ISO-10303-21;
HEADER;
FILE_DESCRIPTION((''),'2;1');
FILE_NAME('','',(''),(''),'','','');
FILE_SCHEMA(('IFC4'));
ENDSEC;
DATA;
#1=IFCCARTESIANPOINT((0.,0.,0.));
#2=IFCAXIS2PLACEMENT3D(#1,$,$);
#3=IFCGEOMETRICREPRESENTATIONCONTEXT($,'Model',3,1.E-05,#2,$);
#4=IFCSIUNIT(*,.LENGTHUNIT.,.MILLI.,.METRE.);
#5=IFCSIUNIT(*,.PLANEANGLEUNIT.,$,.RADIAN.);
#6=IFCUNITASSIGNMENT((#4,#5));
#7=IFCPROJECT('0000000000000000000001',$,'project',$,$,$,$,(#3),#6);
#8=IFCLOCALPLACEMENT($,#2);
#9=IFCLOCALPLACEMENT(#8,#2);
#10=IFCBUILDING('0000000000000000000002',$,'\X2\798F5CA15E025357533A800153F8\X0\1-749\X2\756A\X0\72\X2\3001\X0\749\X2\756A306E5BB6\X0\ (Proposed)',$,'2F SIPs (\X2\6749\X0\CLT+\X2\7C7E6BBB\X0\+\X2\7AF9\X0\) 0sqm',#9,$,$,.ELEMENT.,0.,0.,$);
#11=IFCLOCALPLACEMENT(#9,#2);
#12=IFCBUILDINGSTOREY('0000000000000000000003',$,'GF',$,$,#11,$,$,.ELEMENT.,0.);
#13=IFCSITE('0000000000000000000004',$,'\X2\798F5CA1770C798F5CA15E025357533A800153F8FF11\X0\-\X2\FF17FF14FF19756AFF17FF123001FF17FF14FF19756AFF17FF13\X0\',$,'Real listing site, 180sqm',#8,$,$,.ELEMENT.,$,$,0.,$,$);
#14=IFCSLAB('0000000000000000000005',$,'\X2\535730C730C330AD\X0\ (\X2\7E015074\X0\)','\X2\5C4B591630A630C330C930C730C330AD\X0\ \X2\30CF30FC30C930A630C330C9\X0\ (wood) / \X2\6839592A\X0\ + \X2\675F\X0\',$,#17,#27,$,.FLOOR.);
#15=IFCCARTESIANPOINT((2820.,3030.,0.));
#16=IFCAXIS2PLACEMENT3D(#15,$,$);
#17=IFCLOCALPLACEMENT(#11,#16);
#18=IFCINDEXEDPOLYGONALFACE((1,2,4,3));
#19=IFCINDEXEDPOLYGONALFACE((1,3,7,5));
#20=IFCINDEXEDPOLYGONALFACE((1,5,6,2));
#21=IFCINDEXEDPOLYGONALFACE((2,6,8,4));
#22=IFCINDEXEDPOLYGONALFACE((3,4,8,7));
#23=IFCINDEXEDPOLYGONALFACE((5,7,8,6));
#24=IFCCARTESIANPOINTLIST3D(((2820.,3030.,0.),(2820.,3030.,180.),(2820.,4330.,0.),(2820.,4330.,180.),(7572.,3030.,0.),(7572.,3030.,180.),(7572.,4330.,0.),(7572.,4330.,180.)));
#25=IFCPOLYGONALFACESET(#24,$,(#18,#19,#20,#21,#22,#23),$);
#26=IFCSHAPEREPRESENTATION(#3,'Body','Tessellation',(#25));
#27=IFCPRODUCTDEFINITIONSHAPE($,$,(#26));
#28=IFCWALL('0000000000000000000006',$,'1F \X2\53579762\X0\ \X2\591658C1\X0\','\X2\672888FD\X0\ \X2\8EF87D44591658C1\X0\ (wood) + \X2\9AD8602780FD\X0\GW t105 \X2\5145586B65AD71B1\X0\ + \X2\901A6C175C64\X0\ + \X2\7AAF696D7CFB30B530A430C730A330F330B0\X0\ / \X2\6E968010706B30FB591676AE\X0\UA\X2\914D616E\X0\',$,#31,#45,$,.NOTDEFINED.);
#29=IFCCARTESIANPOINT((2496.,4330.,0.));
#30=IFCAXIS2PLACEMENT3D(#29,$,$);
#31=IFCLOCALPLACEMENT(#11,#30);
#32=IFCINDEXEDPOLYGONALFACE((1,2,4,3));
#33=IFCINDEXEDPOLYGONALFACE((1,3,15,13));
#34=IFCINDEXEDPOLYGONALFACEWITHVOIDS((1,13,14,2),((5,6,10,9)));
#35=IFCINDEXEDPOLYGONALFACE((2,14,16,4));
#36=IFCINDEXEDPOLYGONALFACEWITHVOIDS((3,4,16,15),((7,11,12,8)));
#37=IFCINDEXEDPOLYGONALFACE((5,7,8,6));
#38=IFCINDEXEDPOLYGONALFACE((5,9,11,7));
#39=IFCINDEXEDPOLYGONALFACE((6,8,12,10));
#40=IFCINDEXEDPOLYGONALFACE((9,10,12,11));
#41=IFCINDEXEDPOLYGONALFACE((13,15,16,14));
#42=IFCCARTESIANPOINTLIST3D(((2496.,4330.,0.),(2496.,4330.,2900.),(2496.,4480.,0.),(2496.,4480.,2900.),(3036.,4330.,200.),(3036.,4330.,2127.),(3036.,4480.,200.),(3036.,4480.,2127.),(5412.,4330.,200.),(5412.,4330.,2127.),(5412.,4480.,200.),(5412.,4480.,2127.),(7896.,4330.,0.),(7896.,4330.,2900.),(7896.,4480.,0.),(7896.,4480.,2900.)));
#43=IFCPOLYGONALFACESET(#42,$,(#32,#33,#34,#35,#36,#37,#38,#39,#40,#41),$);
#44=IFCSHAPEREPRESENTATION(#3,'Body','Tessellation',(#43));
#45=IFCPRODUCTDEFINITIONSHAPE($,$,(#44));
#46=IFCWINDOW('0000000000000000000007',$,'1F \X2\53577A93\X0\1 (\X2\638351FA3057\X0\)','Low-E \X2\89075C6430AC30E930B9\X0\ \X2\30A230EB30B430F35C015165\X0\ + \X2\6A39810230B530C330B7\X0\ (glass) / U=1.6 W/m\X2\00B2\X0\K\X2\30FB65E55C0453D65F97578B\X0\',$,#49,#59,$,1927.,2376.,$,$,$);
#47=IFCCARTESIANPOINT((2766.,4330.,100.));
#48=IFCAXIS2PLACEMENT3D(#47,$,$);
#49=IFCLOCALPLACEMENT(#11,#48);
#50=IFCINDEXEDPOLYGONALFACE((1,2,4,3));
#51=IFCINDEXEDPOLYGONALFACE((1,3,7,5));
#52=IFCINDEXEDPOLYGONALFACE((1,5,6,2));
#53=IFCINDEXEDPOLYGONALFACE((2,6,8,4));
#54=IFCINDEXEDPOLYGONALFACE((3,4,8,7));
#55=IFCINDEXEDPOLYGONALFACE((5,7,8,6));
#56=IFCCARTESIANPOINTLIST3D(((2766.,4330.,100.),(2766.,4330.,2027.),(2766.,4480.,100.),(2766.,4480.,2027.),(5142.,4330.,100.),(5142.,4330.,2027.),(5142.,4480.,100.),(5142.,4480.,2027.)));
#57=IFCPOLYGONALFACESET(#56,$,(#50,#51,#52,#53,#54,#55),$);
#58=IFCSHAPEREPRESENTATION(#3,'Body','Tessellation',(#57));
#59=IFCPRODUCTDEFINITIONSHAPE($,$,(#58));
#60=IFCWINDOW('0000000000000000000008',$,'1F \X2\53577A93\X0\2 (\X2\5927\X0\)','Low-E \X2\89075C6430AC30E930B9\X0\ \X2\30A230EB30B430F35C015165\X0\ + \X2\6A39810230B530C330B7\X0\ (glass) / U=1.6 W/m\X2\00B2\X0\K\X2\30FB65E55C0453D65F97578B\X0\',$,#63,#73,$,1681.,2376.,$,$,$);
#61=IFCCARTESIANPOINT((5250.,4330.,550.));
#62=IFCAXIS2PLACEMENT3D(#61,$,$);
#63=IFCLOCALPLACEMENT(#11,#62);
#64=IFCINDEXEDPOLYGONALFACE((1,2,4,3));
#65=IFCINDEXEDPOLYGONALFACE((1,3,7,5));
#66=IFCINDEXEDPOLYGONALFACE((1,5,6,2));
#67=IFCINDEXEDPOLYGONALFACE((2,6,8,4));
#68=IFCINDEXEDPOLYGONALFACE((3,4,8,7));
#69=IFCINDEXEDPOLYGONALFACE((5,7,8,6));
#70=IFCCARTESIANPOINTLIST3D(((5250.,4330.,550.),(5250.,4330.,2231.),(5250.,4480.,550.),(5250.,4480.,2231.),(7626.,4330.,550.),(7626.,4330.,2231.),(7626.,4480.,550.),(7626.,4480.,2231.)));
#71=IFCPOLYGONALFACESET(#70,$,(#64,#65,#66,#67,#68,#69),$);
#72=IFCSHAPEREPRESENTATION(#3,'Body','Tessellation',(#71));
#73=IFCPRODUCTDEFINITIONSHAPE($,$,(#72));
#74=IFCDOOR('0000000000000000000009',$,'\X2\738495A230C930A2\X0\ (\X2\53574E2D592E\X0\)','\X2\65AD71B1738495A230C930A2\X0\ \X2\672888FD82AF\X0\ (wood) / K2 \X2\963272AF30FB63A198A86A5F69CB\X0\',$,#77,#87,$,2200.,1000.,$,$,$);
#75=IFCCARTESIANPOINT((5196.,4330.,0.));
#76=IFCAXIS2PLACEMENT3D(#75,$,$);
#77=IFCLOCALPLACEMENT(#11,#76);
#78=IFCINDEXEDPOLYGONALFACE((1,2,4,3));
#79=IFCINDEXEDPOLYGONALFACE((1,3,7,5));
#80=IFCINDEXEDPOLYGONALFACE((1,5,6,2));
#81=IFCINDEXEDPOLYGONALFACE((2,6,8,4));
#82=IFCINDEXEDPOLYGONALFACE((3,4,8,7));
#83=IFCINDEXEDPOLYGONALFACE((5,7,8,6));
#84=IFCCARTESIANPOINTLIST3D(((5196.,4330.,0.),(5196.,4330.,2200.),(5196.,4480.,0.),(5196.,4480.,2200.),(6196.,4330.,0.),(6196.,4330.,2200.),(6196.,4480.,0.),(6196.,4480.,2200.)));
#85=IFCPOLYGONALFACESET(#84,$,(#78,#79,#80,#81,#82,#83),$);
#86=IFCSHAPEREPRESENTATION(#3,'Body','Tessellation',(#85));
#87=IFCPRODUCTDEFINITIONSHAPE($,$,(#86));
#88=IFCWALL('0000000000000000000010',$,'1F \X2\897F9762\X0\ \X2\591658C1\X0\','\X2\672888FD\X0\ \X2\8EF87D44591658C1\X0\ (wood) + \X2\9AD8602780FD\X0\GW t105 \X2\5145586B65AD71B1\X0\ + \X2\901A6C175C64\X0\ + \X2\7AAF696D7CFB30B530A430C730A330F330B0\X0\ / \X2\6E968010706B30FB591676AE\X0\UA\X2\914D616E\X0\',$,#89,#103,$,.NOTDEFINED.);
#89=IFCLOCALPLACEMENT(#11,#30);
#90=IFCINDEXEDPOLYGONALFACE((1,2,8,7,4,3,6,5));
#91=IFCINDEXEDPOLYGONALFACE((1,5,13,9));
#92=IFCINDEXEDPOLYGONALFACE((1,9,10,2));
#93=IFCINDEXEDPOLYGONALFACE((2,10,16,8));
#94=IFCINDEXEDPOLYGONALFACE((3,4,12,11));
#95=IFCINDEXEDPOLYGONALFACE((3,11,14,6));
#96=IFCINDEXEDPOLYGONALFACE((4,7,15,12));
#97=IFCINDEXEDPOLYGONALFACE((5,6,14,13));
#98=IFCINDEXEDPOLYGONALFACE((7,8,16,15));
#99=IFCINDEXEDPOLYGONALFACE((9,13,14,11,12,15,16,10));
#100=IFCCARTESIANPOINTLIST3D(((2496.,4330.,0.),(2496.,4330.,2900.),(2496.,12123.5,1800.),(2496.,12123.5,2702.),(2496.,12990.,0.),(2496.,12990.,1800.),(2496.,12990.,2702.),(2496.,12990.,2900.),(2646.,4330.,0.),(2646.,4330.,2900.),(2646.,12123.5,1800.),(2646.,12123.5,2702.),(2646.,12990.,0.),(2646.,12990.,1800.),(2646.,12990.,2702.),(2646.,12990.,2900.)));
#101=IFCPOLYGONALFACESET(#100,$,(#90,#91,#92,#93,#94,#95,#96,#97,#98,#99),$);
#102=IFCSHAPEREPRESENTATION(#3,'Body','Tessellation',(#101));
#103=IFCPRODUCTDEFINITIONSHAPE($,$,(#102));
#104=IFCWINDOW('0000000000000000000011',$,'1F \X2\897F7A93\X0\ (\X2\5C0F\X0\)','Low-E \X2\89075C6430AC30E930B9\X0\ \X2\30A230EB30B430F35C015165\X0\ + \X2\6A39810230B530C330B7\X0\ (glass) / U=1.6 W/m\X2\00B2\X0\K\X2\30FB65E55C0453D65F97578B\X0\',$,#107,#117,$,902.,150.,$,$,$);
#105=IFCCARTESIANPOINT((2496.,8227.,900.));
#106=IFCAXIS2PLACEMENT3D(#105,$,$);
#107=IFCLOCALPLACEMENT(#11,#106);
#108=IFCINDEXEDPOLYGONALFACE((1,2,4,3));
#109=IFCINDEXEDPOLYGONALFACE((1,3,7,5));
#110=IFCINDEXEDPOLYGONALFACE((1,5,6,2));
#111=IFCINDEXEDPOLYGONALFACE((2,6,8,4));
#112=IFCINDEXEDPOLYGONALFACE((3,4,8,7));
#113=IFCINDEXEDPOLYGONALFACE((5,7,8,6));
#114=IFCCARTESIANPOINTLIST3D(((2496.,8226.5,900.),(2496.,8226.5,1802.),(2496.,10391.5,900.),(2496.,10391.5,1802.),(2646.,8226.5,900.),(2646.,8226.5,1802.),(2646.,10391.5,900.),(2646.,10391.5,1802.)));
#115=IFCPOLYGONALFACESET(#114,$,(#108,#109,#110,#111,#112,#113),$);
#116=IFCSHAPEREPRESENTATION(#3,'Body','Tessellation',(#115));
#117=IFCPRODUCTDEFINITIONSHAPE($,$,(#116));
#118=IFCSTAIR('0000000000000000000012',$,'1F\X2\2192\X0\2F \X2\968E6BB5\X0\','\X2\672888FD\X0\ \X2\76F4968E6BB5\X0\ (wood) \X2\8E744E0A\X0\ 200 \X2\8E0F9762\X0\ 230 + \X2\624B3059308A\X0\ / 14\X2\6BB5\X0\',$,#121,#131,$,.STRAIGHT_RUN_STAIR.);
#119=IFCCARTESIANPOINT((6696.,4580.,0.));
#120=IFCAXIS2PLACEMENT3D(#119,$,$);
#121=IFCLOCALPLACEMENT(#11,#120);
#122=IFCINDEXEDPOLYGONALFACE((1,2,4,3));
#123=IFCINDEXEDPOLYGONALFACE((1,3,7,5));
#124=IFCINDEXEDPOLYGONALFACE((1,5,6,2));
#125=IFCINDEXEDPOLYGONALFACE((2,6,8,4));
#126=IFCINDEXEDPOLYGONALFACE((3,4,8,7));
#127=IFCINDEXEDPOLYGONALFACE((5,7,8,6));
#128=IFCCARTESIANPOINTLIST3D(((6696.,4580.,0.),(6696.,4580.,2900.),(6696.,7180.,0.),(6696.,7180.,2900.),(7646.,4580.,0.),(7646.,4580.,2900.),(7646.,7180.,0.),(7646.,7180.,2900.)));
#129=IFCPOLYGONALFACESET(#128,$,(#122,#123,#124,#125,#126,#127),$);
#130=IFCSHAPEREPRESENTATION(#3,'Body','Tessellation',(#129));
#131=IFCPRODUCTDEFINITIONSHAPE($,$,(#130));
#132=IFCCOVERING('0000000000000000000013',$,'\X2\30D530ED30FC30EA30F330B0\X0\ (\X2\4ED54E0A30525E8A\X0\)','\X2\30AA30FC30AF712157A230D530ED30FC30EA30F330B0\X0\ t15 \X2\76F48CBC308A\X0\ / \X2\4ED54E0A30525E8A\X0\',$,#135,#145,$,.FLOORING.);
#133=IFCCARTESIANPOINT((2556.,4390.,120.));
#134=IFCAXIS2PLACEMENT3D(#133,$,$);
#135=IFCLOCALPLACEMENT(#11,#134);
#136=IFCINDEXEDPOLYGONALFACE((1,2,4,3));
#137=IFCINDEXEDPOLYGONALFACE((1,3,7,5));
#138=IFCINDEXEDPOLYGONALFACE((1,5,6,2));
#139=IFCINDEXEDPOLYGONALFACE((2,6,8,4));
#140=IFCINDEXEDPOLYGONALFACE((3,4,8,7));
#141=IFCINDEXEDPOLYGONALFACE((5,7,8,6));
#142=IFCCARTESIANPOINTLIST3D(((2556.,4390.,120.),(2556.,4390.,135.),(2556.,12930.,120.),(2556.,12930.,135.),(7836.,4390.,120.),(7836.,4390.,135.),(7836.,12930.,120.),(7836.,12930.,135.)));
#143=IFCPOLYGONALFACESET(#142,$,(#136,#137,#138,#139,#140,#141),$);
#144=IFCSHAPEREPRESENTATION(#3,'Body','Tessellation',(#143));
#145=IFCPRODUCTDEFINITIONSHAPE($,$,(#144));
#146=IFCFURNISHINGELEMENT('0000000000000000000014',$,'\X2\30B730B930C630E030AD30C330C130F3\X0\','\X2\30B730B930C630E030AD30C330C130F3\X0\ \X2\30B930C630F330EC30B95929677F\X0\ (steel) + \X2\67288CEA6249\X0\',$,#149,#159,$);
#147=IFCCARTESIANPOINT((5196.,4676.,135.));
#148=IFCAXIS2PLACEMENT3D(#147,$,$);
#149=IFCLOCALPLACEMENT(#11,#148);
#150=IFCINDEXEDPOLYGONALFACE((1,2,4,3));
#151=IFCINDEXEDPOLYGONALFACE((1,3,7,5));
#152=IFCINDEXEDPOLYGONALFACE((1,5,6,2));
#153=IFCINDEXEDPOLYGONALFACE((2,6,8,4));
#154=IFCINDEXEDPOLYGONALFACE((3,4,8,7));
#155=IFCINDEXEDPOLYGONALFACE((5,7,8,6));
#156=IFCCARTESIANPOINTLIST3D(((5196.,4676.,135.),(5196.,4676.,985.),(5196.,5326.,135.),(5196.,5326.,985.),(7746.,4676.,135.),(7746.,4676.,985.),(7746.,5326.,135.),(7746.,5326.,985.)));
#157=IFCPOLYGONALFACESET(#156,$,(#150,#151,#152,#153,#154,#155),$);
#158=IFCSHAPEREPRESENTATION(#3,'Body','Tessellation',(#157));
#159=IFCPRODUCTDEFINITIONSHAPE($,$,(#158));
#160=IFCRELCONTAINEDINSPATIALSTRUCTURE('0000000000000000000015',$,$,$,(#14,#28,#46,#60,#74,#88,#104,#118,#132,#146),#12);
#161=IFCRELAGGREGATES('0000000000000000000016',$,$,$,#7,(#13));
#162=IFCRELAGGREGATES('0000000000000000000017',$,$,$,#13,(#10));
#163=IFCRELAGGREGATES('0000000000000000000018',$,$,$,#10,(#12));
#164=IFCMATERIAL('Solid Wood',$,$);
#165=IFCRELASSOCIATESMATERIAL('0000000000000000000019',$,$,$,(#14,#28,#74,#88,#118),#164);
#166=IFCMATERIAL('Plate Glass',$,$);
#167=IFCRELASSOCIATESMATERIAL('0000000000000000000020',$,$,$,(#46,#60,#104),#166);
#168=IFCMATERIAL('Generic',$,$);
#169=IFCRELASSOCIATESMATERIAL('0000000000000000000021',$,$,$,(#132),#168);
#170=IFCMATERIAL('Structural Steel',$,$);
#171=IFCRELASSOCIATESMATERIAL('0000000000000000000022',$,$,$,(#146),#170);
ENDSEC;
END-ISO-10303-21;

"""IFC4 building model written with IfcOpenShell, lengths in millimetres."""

from ifc_helpers import new_model, si_unit, frame, frame_2d, origin, place, context, project, spatial, rectangle, extrude, material, element, fill, save


model = new_model("IFC4")

# Units and contexts
model_context = context("Model", 3, precision=1e-05, world=origin())
ifc_project = project(units=[si_unit("LENGTHUNIT", "METRE", prefix="MILLI"), si_unit("PLANEANGLEUNIT", "RADIAN")], contexts=[model_context])

# Site, building, storey
site_placement = place(None, origin())
site = spatial("IfcSite", under=ifc_project, at=site_placement, Name="福岡県福岡市南区老司１-７４９番７２、７４９番７３", ObjectType="Real listing site, 180sqm", CompositionType="ELEMENT", RefElevation=0.0)
building_placement = place(site_placement, origin())
building = spatial("IfcBuilding", under=site, at=building_placement, Name="福岡市南区老司1-749番72、749番の家 (Proposed)", ObjectType="2F SIPs (杉CLT+籾殻+竹) 0sqm", CompositionType="ELEMENT", ElevationOfRefHeight=0.0, ElevationOfTerrain=0.0)
storey_placement = place(building_placement, origin())
storey = spatial("IfcBuildingStorey", under=building, at=storey_placement, Name="GF", CompositionType="ELEMENT", Elevation=0.0)

# Slab
ifc_material_1 = material(Name="Solid Wood")
slab_1_placement = place(storey_placement, frame((2820.0, 3030.0, 0.0)))
element("IfcSlab", 1, at=slab_1_placement, inside=storey, material=ifc_material_1, Name="南デッキ (縁側)", Description="屋外ウッドデッキ ハードウッド (wood) / 根太 + 束", PredefinedType="FLOOR", context=model_context, shape_type="SweptSolid", body=[
    extrude(rectangle(XDim=4752.0, YDim=1300.0, at=frame_2d((2376.0, 650.0))), frame((2820.0, 3030.0, 0.0)), (0.0, 0.0, 1.0), 180.0),
])

# Wall, openings, windows, door
wall_1_placement = place(storey_placement, frame((2496.0, 4330.0, 0.0)))
wall_1 = element("IfcWall", 2, at=wall_1_placement, inside=storey, material=ifc_material_1, Name="1F 南面 外壁", Description="木製 軸組外壁 (wood) + 高性能GW t105 充填断熱 + 通気層 + 窯業系サイディング / 準耐火・外皮UA配慮", PredefinedType="NOTDEFINED", context=model_context, shape_type="SweptSolid", body=[
    extrude(rectangle(XDim=5400.0, YDim=150.0, at=frame_2d((2700.0, 75.0))), frame((2496.0, 4330.0, 0.0)), (0.0, 0.0, 1.0), 2900.0),
])
opening_1_placement = place(storey_placement, frame((2766.0, 4330.0, 100.0)))
opening_1 = element("IfcOpeningElement", 3, at=opening_1_placement, cuts=wall_1, PredefinedType="NOTDEFINED", context=model_context, shape_type="SweptSolid", body=[
    extrude(rectangle(XDim=2376.0, YDim=150.0, at=frame_2d((1188.0, 75.0))), frame((2766.0, 4330.0, 100.0)), (0.0, 0.0, 1.0), 1927.0),
])
opening_2_placement = place(storey_placement, frame((5250.0, 4330.0, 550.0)))
opening_2 = element("IfcOpeningElement", 4, at=opening_2_placement, cuts=wall_1, PredefinedType="NOTDEFINED", context=model_context, shape_type="SweptSolid", body=[
    extrude(rectangle(XDim=2376.0, YDim=150.0, at=frame_2d((1188.0, 75.0))), frame((5250.0, 4330.0, 550.0)), (0.0, 0.0, 1.0), 1681.0),
])
opening_3_placement = place(storey_placement, frame((5196.0, 4330.0, 0.0)))
opening_3 = element("IfcOpeningElement", 5, at=opening_3_placement, cuts=wall_1, PredefinedType="NOTDEFINED", context=model_context, shape_type="SweptSolid", body=[
    extrude(rectangle(XDim=1000.0, YDim=150.0, at=frame_2d((500.0, 75.0))), frame((5196.0, 4330.0, 0.0)), (0.0, 0.0, 1.0), 2200.0),
])
ifc_material_2 = material(Name="Plate Glass")
window_1_placement = place(storey_placement, frame((2766.0, 4330.0, 100.0)))
window_1 = element("IfcWindow", 6, at=window_1_placement, inside=storey, material=ifc_material_2, Name="1F 南窓1 (掃出し)", Description="Low-E 複層ガラス アルゴン封入 + 樹脂サッシ (glass) / U=1.6 W/m²K・日射取得型", OverallHeight=1927.0, OverallWidth=2376.0, context=model_context, shape_type="SweptSolid", body=[
    extrude(rectangle(XDim=2376.0, YDim=150.0, at=frame_2d((1188.0, 75.0))), frame((2766.0, 4330.0, 100.0)), (0.0, 0.0, 1.0), 1927.0),
])
fill(opening_1, window_1)
window_2_placement = place(storey_placement, frame((5250.0, 4330.0, 550.0)))
window_2 = element("IfcWindow", 7, at=window_2_placement, inside=storey, material=ifc_material_2, Name="1F 南窓2 (大)", Description="Low-E 複層ガラス アルゴン封入 + 樹脂サッシ (glass) / U=1.6 W/m²K・日射取得型", OverallHeight=1681.0, OverallWidth=2376.0, context=model_context, shape_type="SweptSolid", body=[
    extrude(rectangle(XDim=2376.0, YDim=150.0, at=frame_2d((1188.0, 75.0))), frame((5250.0, 4330.0, 550.0)), (0.0, 0.0, 1.0), 1681.0),
])
fill(opening_2, window_2)
door_placement = place(storey_placement, frame((5196.0, 4330.0, 0.0)))
door = element("IfcDoor", 8, at=door_placement, inside=storey, material=ifc_material_1, Name="玄関ドア (南中央)", Description="断熱玄関ドア 木製芯 (wood) / K2 防犯・採風機構", OverallHeight=2200.0, OverallWidth=1000.0, context=model_context, shape_type="SweptSolid", body=[
    extrude(rectangle(XDim=1000.0, YDim=150.0, at=frame_2d((500.0, 75.0))), frame((5196.0, 4330.0, 0.0)), (0.0, 0.0, 1.0), 2200.0),
])
fill(opening_3, door)

# Wall, opening, window
wall_2_placement = place(storey_placement, frame((2496.0, 4330.0, 0.0)))
wall_2 = element("IfcWall", 9, at=wall_2_placement, inside=storey, material=ifc_material_1, Name="1F 西面 外壁", Description="木製 軸組外壁 (wood) + 高性能GW t105 充填断熱 + 通気層 + 窯業系サイディング / 準耐火・外皮UA配慮", PredefinedType="NOTDEFINED", context=model_context, shape_type="SweptSolid", body=[
    extrude(rectangle(XDim=150.0, YDim=8660.0, at=frame_2d((75.0, 4330.0))), frame((2496.0, 4330.0, 0.0)), (0.0, 0.0, 1.0), 2900.0),
])
opening_4_placement = place(storey_placement, frame((2496.0, 8227.0, 900.0)))
opening_4 = element("IfcOpeningElement", 10, at=opening_4_placement, cuts=wall_2, PredefinedType="NOTDEFINED", context=model_context, shape_type="SweptSolid", body=[
    extrude(rectangle(XDim=150.0, YDim=2165.0, at=frame_2d((75.0, 1082.0))), frame((2496.0, 8227.0, 900.0)), (0.0, 0.0, 1.0), 902.0),
])
window_3_placement = place(storey_placement, frame((2496.0, 8227.0, 900.0)))
window_3 = element("IfcWindow", 11, at=window_3_placement, inside=storey, material=ifc_material_2, Name="1F 西窓 (小)", Description="Low-E 複層ガラス アルゴン封入 + 樹脂サッシ (glass) / U=1.6 W/m²K・日射取得型", OverallHeight=902.0, OverallWidth=150.0, context=model_context, shape_type="SweptSolid", body=[
    extrude(rectangle(XDim=150.0, YDim=2165.0, at=frame_2d((75.0, 1082.0))), frame((2496.0, 8227.0, 900.0)), (0.0, 0.0, 1.0), 902.0),
])
fill(opening_4, window_3)

# Stair
stair_placement = place(storey_placement, frame((6696.0, 4580.0, 0.0)))
element("IfcStair", 12, at=stair_placement, inside=storey, material=ifc_material_1, Name="1F→2F 階段", Description="木製 直階段 (wood) 蹴上 200 踏面 230 + 手すり / 14段", PredefinedType="STRAIGHT_RUN_STAIR", context=model_context, shape_type="SweptSolid", body=[
    extrude(rectangle(XDim=950.0, YDim=2600.0, at=frame_2d((475.0, 1300.0))), frame((6696.0, 4580.0, 0.0)), (0.0, 0.0, 1.0), 2900.0),
])

# Covering
ifc_material_3 = material(Name="Generic")
covering_placement = place(storey_placement, frame((2556.0, 4390.0, 120.0)))
element("IfcCovering", 13, at=covering_placement, inside=storey, material=ifc_material_3, Name="フローリング (仕上げ床)", Description="オーク無垢フローリング t15 直貼り / 仕上げ床", PredefinedType="FLOORING", context=model_context, shape_type="SweptSolid", body=[
    extrude(rectangle(XDim=5280.0, YDim=8540.0, at=frame_2d((2640.0, 4270.0))), frame((2556.0, 4390.0, 120.0)), (0.0, 0.0, 1.0), 15.0),
])

# Furnishing element
ifc_material_4 = material(Name="Structural Steel")
furnishing_placement = place(storey_placement, frame((5196.0, 4676.0, 135.0)))
element("IfcFurnishingElement", 14, at=furnishing_placement, inside=storey, material=ifc_material_4, Name="システムキッチン", Description="システムキッチン ステンレス天板 (steel) + 木質扉", context=model_context, shape_type="SweptSolid", body=[
    extrude(rectangle(XDim=2550.0, YDim=650.0, at=frame_2d((1275.0, 325.0))), frame((5196.0, 4676.0, 135.0)), (0.0, 0.0, 1.0), 850.0),
])

save(model, "model.ifc")
